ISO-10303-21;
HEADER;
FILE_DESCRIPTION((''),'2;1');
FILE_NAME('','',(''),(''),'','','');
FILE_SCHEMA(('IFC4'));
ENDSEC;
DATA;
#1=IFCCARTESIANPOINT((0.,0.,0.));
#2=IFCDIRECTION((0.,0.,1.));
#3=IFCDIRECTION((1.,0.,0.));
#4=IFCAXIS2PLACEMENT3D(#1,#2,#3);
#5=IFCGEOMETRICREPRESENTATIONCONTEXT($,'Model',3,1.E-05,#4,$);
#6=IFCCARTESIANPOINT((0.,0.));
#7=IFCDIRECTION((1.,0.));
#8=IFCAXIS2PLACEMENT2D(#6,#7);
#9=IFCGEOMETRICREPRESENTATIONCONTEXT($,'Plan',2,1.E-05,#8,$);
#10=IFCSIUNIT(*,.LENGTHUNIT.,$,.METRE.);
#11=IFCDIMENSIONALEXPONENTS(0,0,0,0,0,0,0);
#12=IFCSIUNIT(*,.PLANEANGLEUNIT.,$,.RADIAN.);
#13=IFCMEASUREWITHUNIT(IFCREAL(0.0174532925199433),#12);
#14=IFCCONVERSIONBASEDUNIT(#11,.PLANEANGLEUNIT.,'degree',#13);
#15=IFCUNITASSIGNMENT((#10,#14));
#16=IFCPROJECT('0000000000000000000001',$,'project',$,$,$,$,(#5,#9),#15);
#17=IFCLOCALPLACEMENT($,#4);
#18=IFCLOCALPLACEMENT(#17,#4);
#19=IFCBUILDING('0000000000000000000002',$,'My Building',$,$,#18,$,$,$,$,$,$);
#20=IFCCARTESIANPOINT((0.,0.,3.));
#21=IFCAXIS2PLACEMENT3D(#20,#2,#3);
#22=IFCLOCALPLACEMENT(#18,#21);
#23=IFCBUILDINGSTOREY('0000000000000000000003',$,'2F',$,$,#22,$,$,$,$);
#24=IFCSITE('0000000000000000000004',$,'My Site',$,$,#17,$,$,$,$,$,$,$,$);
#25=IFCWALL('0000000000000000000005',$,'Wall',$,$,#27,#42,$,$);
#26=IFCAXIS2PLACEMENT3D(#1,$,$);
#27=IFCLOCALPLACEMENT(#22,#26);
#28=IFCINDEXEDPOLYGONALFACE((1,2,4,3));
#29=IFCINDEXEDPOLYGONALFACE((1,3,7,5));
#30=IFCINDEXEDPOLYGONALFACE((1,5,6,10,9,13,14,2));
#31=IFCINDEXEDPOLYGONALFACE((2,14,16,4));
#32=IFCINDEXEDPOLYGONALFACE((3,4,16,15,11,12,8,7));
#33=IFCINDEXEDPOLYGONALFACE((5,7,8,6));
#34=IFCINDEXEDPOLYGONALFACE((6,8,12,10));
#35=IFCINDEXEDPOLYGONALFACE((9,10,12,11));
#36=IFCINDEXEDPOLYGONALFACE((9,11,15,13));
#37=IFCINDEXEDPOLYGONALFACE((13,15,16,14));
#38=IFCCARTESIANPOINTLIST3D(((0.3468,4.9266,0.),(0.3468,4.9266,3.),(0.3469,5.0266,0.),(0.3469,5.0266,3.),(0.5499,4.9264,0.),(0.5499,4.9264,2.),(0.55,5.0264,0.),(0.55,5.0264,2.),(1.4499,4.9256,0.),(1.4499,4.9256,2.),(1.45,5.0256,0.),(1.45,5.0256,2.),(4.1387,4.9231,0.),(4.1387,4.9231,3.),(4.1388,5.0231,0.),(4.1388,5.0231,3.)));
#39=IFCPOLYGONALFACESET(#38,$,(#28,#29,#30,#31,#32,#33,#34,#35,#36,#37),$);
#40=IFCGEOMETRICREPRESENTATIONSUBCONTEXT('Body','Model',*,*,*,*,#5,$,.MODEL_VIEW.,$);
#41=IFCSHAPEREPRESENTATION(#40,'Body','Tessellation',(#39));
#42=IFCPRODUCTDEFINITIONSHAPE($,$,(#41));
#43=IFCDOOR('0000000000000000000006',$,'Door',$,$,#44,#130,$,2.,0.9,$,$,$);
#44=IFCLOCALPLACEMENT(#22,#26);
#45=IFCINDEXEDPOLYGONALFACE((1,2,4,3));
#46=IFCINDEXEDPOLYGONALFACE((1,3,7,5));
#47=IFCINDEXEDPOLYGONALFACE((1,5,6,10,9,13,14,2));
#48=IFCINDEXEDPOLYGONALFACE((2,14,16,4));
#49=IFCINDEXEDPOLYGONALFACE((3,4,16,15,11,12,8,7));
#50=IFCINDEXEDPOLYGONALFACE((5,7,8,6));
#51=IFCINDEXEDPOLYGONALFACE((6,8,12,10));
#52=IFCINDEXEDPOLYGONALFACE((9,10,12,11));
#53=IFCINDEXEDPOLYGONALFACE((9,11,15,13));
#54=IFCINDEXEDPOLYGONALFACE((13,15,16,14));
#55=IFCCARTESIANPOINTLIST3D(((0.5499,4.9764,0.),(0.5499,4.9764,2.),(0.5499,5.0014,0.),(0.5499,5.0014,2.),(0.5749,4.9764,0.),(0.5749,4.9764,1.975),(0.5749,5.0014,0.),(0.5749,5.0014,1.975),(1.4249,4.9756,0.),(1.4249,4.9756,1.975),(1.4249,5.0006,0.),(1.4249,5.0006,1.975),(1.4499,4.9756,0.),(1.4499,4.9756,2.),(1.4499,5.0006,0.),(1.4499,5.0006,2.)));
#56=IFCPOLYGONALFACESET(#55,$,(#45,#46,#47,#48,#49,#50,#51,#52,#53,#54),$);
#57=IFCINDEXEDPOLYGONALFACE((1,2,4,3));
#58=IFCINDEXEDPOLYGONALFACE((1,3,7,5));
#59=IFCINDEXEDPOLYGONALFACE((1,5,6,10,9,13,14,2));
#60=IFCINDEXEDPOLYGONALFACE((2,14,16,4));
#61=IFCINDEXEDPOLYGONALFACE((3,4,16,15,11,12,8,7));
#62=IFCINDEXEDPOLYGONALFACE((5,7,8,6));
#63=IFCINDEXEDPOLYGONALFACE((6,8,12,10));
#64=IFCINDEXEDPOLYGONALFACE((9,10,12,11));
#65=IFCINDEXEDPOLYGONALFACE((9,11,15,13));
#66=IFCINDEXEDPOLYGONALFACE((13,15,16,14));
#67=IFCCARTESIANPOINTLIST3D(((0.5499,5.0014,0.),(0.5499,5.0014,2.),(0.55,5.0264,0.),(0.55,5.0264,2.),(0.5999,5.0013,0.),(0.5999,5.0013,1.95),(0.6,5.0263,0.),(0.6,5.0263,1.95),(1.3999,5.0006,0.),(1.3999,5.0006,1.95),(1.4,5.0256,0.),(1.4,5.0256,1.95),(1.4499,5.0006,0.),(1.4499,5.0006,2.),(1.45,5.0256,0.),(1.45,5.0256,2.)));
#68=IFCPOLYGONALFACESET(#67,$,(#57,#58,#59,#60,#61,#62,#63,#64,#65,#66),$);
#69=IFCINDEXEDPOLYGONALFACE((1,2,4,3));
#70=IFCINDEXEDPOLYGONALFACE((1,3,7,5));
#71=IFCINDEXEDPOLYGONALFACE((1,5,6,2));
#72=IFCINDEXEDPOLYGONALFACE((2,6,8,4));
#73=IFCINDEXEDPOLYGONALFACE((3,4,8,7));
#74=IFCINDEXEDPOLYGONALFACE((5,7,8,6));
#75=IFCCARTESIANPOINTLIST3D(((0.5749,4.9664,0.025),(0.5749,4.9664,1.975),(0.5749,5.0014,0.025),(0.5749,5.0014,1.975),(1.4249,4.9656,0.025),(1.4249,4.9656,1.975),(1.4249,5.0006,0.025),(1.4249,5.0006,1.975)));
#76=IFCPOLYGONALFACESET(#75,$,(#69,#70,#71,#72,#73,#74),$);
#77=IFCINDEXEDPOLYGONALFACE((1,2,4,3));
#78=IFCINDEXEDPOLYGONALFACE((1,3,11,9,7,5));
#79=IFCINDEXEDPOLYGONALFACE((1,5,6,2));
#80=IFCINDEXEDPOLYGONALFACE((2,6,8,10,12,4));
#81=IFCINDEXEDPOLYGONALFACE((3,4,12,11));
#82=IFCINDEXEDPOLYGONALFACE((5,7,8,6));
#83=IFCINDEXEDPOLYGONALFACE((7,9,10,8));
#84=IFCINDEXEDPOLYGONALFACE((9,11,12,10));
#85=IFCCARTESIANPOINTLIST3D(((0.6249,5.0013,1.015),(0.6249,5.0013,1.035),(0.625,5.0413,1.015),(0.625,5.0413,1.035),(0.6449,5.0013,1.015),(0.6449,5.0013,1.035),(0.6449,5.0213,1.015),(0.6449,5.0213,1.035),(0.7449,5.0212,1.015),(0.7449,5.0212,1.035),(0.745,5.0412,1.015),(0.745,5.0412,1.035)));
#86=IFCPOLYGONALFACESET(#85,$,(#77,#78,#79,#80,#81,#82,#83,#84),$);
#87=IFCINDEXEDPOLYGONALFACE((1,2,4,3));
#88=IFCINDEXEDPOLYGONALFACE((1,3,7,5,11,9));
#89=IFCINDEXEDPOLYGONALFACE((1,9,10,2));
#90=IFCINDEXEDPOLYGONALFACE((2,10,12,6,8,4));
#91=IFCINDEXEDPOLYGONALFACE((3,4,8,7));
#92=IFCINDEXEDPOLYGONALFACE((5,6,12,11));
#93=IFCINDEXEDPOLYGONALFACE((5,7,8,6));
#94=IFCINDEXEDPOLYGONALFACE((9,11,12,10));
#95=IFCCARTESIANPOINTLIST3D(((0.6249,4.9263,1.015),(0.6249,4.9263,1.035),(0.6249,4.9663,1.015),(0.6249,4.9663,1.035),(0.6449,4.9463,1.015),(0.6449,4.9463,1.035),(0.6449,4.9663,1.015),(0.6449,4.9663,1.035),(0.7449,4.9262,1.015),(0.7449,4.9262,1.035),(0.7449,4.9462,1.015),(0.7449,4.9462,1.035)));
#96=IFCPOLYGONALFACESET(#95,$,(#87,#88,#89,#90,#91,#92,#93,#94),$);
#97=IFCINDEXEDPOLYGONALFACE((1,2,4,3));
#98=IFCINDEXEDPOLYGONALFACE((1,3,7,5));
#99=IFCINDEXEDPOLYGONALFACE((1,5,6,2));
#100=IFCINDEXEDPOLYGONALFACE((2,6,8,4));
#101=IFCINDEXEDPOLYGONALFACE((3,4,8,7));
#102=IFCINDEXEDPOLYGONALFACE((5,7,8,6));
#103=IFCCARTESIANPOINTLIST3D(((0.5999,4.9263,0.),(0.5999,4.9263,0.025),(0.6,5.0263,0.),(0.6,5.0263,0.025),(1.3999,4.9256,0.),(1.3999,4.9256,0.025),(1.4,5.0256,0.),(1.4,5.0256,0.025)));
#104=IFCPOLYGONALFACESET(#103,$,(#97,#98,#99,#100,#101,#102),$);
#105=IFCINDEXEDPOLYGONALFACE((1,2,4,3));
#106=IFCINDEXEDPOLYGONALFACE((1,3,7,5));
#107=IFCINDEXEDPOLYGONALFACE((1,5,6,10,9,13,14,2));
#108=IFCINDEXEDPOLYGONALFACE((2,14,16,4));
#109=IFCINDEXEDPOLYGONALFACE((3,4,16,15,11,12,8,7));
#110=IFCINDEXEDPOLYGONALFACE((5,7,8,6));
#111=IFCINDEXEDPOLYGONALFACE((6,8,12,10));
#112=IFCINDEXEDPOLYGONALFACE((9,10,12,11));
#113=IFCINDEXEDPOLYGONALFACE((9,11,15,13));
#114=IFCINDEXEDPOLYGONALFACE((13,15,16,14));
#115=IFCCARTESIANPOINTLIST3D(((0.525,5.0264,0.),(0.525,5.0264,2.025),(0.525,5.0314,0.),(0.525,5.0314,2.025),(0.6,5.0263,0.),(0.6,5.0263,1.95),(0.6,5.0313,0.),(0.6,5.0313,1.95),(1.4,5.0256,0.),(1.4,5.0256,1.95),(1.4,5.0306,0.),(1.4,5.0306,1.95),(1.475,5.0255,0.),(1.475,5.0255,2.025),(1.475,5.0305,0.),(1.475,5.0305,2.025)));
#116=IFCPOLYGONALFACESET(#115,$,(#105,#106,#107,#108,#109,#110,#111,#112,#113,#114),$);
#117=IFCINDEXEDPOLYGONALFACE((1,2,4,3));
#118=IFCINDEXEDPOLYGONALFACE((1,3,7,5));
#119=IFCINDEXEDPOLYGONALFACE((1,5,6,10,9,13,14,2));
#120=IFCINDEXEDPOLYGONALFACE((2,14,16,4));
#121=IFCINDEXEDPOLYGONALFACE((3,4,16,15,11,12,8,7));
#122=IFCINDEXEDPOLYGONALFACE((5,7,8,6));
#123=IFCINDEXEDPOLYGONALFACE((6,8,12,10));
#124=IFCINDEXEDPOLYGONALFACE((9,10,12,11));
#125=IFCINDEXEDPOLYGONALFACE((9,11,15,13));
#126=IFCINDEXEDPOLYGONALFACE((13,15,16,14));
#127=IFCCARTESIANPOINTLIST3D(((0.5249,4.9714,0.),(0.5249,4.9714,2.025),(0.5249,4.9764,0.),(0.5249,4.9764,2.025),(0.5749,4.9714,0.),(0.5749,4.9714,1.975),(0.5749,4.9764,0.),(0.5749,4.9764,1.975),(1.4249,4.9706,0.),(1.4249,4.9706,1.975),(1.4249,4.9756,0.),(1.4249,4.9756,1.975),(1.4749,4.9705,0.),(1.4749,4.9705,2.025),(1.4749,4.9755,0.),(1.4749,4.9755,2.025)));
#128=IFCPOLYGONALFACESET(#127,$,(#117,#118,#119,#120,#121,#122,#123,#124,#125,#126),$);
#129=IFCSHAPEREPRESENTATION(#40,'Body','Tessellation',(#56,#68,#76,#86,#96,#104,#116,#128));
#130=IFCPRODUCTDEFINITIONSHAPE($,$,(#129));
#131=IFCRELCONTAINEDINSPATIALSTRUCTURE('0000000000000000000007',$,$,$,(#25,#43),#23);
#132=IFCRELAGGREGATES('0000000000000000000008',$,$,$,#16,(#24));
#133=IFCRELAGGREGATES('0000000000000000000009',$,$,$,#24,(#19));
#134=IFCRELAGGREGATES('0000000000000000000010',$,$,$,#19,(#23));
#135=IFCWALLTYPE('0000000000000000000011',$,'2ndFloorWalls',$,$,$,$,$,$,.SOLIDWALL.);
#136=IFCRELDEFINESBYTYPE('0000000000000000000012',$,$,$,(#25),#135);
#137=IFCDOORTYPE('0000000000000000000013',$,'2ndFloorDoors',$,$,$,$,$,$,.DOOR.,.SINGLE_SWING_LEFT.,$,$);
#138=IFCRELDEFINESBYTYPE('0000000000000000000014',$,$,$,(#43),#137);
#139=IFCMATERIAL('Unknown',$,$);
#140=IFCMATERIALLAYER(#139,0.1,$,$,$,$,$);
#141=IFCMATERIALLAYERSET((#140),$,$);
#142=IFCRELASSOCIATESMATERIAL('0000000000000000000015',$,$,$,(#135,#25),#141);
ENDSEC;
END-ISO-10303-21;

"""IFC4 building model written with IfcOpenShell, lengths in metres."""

from ifc_helpers import new_model, entity, si_unit, converted_unit, frame, origin_with_axes, origin_2d_with_axis, place, context, subcontext, project, spatial, line, indexed_curve, outline, extrude, shape, source, transform, mapped, material, layer, layer_set, layer_usage, type_object, type_shapes, element, fill, save


model = new_model("IFC4")

# Units and contexts
model_context = context("Model", 3, precision=1e-05, world=origin_with_axes())
plan_context = context("Plan", 2, precision=1e-05, world=origin_2d_with_axis())
body_context_1 = subcontext(model_context, "Body", "Model", "MODEL_VIEW")
body_context_2 = subcontext(plan_context, "Body", "Plan", "PLAN_VIEW")
ifc_project = project(units=[si_unit("LENGTHUNIT", "METRE"), converted_unit("PLANEANGLEUNIT", "degree", entity("IfcReal", 0.0174532925199433), si_unit("PLANEANGLEUNIT", "RADIAN"), dimensions=[0, 0, 0, 0, 0, 0, 0])], contexts=[model_context, plan_context])

# Site, building, storey
site_placement = place(None, origin_with_axes())
site = spatial("IfcSite", under=ifc_project, at=site_placement, Name="My Site")
building_placement = place(site_placement, origin_with_axes())
building = spatial("IfcBuilding", under=site, at=building_placement, Name="My Building")
storey_placement = place(building_placement, frame((0.0, 0.0, 3.0), z_axis=(0.0, 0.0, 1.0), x_axis=(1.0, 0.0, 0.0)))
storey = spatial("IfcBuildingStorey", under=building, at=storey_placement, Name="2F")

# Shared definitions
ifc_material = material(Name="Unknown")

# Shared definitions
ifc_layer_1 = layer(ifc_material, 0.1)
ifc_layer_set_1 = layer_set([ifc_layer_1])
wall_type = type_object("IfcWallType", Name="2ndFloorWalls", PredefinedType="SOLIDWALL", material=ifc_layer_set_1)

# Wall, opening, door
ifc_layer_usage_1 = layer_usage(ifc_layer_set_1, "AXIS2", "POSITIVE", 0.0)
wall_1_placement = place(storey_placement, frame((4.1388, 5.0231, 0.0), z_axis=(0.0, 0.0, 1.0), x_axis=(-1.0, 0.000917, 0.0)))
wall_1 = element("IfcWall", 1, at=wall_1_placement, inside=storey, type_object=wall_type, material=ifc_layer_usage_1, Name="Wall", context=body_context_1, shape_type="SweptSolid", body=[
    extrude(outline(indexed_curve([(0.0, 0.0), (0.0, 0.1), (3.7919, 0.1), (3.7919, 0.0)], segments=[line(1, 2, 3, 4, 1)])), origin_with_axes(), (0.0, 0.0, 1.0), 3.0),
])
shared_shape_1 = source(origin_with_axes(), body_context_1, "Body", "SweptSolid", [
    extrude(outline(indexed_curve([(0.0, 0.0), (0.9, 0.0), (0.9, 2.0), (0.0, 2.0)], segments=[line(1, 2, 3, 4, 1)])), frame((0.0, -0.6, 0.0), z_axis=(0.0, -1.0, 0.0), x_axis=(1.0, 0.0, 0.0)), (0.0, 0.0, -1.0), 1.2),
])
opening_1_placement = place(wall_1_placement, frame((2.6888, 0.0, 0.0), z_axis=(0.0, 0.0, 1.0), x_axis=(1.0, 0.0, 0.0)))
opening_1 = element("IfcOpeningElement", 2, at=opening_1_placement, cuts=wall_1, PredefinedType="OPENING", context=body_context_1, shape_type="MappedRepresentation", body=[
    mapped(shared_shape_1, transform((0.0, 0.0, 0.0), x_axis=(1.0, 0.0, 0.0), y_axis=(0.0, 1.0, 0.0), z_axis=(0.0, 0.0, 1.0), scale=1.0)),
])
door_type = type_object("IfcDoorType", Name="2ndFloorDoors", OperationType="SINGLE_SWING_LEFT", PredefinedType="DOOR")
shared_shape_2 = source(origin_with_axes(), body_context_1, "Body", "SweptSolid", [
    extrude(outline(indexed_curve([(0.0, 0.0), (0.0, 2.0), (0.9, 2.0), (0.9, 0.0), (0.875, 0.0), (0.875, 1.975), (0.025, 1.975), (0.025, 0.0)], segments=[line(1, 2, 3, 4, 5, 6, 7, 8, 1)])), frame((0.0, 0.025, 0.0), z_axis=(0.0, -1.0, 0.0), x_axis=(1.0, 0.0, 0.0)), (0.0, 0.0, -1.0), 0.025),
    extrude(outline(indexed_curve([(0.0, 0.0), (0.0, 2.0), (0.9, 2.0), (0.9, 0.0), (0.85, 0.0), (0.85, 1.95), (0.05, 1.95), (0.05, 0.0)], segments=[line(1, 2, 3, 4, 5, 6, 7, 8, 1)])), frame((0.0, 0.0, 0.0), z_axis=(0.0, -1.0, 0.0), x_axis=(1.0, 0.0, 0.0)), (0.0, 0.0, -1.0), 0.025),
    extrude(outline(indexed_curve([(0.0, 0.0), (0.85, 0.0), (0.85, 0.035), (0.0, 0.035)], segments=[line(1, 2, 3, 4, 1)])), frame((0.025, 0.025, 0.025), z_axis=(0.0, 0.0, 1.0), x_axis=(1.0, 0.0, 0.0)), (0.0, 0.0, 1.0), 1.95),
    extrude(outline(indexed_curve([(0.0, 0.0), (0.0, -0.04), (-0.12, -0.04), (-0.12, -0.02), (-0.02, -0.02), (-0.02, 0.0)], segments=[line(1, 2, 3, 4, 5, 6, 1)])), frame((0.825, 0.025, 1.015), z_axis=(0.0, 0.0, 1.0), x_axis=(1.0, 0.0, 0.0)), (0.0, 0.0, 1.0), 0.02),
    extrude(outline(indexed_curve([(0.0, 0.0), (0.0, 0.04), (-0.12, 0.04), (-0.12, 0.02), (-0.02, 0.02), (-0.02, 0.0)], segments=[line(1, 2, 3, 4, 5, 6, 1)])), frame((0.825, 0.06, 1.015), z_axis=(0.0, 0.0, 1.0), x_axis=(1.0, 0.0, 0.0)), (0.0, 0.0, 1.0), 0.02),
    extrude(outline(indexed_curve([(0.0, 0.0), (0.8, 0.0), (0.8, 0.1), (0.0, 0.1)], segments=[line(1, 2, 3, 4, 1)])), frame((0.05, 0.0, 0.0), z_axis=(0.0, 0.0, 1.0), x_axis=(1.0, 0.0, 0.0)), (0.0, 0.0, 1.0), 0.025),
    extrude(outline(indexed_curve([(0.0, 0.0), (0.0, 2.025), (0.95, 2.025), (0.95, 0.0), (0.875, 0.0), (0.875, 1.95), (0.075, 1.95), (0.075, 0.0)], segments=[line(1, 2, 3, 4, 5, 6, 7, 8, 1)])), frame((-0.025, -0.005, 0.0), z_axis=(0.0, -1.0, 0.0), x_axis=(1.0, 0.0, 0.0)), (0.0, 0.0, -1.0), 0.005),
    extrude(outline(indexed_curve([(0.0, 0.0), (0.0, 2.025), (0.95, 2.025), (0.95, 0.0), (0.9, 0.0), (0.9, 1.975), (0.05, 1.975), (0.05, 0.0)], segments=[line(1, 2, 3, 4, 5, 6, 7, 8, 1)])), frame((-0.025, 0.05, 0.0), z_axis=(0.0, -1.0, 0.0), x_axis=(1.0, 0.0, 0.0)), (0.0, 0.0, -1.0), 0.005),
])
shared_shape_3 = source(origin_with_axes(), body_context_2, "Body", "Curve2D", [
    entity("IfcIndexedPolyCurve", entity("IfcCartesianPointList2D", [[0.0, 0.0], [0.0, 0.05], [0.025, 0.05], [0.025, 0.025], [0.05, 0.025], [0.05, 0.0]]), [entity("IfcLineIndex", [1, 2, 3, 4, 5, 6, 1])]),
    entity("IfcIndexedPolyCurve", entity("IfcCartesianPointList2D", [[0.9, 0.0], [0.9, 0.05], [0.875, 0.05], [0.875, 0.025], [0.85, 0.025], [0.85, 0.0]]), [entity("IfcLineIndex", [1, 2, 3, 4, 5, 6, 1])]),
    entity("IfcTrimmedCurve", entity("IfcEllipse", entity("IfcAxis2Placement2D", entity("IfcCartesianPoint", [0.06, 0.05]), entity("IfcDirection", [1.0, 0.0])), 0.815, 0.85), [entity("IfcCartesianPoint", [0.875, 0.05])], [entity("IfcCartesianPoint", [0.06, 0.9])], True, "CARTESIAN"),
    entity("IfcIndexedPolyCurve", entity("IfcCartesianPointList2D", [[0.025, 0.05], [0.06, 0.05], [0.06, 0.9], [0.025, 0.9]]), [entity("IfcLineIndex", [1, 2, 3, 4, 1])]),
])
type_shapes(door_type, [shared_shape_2, shared_shape_3])
door_placement = place(opening_1_placement, frame((0.0, 0.0, 0.0), z_axis=(0.0, 0.0, 1.0), x_axis=(1.0, 0.0, 0.0)))
door = element("IfcDoor", 3, at=door_placement, inside=storey, type_object=door_type, Name="Door", OverallHeight=2.0, OverallWidth=0.9, shapes=[
    shape(body_context_1, "Body", "MappedRepresentation", [mapped(shared_shape_2, transform((0.0, 0.0, 0.0), x_axis=(1.0, 0.0, 0.0), y_axis=(0.0, 1.0, 0.0), z_axis=(0.0, 0.0, 1.0), scale=1.0))]),
    shape(body_context_2, "Body", "MappedRepresentation", [mapped(shared_shape_3, transform((0.0, 0.0, 0.0), x_axis=(1.0, 0.0, 0.0), y_axis=(0.0, 1.0, 0.0), z_axis=(0.0, 0.0, 1.0), scale=1.0))]),
])
fill(opening_1, door)

save(model, "model.ifc")
